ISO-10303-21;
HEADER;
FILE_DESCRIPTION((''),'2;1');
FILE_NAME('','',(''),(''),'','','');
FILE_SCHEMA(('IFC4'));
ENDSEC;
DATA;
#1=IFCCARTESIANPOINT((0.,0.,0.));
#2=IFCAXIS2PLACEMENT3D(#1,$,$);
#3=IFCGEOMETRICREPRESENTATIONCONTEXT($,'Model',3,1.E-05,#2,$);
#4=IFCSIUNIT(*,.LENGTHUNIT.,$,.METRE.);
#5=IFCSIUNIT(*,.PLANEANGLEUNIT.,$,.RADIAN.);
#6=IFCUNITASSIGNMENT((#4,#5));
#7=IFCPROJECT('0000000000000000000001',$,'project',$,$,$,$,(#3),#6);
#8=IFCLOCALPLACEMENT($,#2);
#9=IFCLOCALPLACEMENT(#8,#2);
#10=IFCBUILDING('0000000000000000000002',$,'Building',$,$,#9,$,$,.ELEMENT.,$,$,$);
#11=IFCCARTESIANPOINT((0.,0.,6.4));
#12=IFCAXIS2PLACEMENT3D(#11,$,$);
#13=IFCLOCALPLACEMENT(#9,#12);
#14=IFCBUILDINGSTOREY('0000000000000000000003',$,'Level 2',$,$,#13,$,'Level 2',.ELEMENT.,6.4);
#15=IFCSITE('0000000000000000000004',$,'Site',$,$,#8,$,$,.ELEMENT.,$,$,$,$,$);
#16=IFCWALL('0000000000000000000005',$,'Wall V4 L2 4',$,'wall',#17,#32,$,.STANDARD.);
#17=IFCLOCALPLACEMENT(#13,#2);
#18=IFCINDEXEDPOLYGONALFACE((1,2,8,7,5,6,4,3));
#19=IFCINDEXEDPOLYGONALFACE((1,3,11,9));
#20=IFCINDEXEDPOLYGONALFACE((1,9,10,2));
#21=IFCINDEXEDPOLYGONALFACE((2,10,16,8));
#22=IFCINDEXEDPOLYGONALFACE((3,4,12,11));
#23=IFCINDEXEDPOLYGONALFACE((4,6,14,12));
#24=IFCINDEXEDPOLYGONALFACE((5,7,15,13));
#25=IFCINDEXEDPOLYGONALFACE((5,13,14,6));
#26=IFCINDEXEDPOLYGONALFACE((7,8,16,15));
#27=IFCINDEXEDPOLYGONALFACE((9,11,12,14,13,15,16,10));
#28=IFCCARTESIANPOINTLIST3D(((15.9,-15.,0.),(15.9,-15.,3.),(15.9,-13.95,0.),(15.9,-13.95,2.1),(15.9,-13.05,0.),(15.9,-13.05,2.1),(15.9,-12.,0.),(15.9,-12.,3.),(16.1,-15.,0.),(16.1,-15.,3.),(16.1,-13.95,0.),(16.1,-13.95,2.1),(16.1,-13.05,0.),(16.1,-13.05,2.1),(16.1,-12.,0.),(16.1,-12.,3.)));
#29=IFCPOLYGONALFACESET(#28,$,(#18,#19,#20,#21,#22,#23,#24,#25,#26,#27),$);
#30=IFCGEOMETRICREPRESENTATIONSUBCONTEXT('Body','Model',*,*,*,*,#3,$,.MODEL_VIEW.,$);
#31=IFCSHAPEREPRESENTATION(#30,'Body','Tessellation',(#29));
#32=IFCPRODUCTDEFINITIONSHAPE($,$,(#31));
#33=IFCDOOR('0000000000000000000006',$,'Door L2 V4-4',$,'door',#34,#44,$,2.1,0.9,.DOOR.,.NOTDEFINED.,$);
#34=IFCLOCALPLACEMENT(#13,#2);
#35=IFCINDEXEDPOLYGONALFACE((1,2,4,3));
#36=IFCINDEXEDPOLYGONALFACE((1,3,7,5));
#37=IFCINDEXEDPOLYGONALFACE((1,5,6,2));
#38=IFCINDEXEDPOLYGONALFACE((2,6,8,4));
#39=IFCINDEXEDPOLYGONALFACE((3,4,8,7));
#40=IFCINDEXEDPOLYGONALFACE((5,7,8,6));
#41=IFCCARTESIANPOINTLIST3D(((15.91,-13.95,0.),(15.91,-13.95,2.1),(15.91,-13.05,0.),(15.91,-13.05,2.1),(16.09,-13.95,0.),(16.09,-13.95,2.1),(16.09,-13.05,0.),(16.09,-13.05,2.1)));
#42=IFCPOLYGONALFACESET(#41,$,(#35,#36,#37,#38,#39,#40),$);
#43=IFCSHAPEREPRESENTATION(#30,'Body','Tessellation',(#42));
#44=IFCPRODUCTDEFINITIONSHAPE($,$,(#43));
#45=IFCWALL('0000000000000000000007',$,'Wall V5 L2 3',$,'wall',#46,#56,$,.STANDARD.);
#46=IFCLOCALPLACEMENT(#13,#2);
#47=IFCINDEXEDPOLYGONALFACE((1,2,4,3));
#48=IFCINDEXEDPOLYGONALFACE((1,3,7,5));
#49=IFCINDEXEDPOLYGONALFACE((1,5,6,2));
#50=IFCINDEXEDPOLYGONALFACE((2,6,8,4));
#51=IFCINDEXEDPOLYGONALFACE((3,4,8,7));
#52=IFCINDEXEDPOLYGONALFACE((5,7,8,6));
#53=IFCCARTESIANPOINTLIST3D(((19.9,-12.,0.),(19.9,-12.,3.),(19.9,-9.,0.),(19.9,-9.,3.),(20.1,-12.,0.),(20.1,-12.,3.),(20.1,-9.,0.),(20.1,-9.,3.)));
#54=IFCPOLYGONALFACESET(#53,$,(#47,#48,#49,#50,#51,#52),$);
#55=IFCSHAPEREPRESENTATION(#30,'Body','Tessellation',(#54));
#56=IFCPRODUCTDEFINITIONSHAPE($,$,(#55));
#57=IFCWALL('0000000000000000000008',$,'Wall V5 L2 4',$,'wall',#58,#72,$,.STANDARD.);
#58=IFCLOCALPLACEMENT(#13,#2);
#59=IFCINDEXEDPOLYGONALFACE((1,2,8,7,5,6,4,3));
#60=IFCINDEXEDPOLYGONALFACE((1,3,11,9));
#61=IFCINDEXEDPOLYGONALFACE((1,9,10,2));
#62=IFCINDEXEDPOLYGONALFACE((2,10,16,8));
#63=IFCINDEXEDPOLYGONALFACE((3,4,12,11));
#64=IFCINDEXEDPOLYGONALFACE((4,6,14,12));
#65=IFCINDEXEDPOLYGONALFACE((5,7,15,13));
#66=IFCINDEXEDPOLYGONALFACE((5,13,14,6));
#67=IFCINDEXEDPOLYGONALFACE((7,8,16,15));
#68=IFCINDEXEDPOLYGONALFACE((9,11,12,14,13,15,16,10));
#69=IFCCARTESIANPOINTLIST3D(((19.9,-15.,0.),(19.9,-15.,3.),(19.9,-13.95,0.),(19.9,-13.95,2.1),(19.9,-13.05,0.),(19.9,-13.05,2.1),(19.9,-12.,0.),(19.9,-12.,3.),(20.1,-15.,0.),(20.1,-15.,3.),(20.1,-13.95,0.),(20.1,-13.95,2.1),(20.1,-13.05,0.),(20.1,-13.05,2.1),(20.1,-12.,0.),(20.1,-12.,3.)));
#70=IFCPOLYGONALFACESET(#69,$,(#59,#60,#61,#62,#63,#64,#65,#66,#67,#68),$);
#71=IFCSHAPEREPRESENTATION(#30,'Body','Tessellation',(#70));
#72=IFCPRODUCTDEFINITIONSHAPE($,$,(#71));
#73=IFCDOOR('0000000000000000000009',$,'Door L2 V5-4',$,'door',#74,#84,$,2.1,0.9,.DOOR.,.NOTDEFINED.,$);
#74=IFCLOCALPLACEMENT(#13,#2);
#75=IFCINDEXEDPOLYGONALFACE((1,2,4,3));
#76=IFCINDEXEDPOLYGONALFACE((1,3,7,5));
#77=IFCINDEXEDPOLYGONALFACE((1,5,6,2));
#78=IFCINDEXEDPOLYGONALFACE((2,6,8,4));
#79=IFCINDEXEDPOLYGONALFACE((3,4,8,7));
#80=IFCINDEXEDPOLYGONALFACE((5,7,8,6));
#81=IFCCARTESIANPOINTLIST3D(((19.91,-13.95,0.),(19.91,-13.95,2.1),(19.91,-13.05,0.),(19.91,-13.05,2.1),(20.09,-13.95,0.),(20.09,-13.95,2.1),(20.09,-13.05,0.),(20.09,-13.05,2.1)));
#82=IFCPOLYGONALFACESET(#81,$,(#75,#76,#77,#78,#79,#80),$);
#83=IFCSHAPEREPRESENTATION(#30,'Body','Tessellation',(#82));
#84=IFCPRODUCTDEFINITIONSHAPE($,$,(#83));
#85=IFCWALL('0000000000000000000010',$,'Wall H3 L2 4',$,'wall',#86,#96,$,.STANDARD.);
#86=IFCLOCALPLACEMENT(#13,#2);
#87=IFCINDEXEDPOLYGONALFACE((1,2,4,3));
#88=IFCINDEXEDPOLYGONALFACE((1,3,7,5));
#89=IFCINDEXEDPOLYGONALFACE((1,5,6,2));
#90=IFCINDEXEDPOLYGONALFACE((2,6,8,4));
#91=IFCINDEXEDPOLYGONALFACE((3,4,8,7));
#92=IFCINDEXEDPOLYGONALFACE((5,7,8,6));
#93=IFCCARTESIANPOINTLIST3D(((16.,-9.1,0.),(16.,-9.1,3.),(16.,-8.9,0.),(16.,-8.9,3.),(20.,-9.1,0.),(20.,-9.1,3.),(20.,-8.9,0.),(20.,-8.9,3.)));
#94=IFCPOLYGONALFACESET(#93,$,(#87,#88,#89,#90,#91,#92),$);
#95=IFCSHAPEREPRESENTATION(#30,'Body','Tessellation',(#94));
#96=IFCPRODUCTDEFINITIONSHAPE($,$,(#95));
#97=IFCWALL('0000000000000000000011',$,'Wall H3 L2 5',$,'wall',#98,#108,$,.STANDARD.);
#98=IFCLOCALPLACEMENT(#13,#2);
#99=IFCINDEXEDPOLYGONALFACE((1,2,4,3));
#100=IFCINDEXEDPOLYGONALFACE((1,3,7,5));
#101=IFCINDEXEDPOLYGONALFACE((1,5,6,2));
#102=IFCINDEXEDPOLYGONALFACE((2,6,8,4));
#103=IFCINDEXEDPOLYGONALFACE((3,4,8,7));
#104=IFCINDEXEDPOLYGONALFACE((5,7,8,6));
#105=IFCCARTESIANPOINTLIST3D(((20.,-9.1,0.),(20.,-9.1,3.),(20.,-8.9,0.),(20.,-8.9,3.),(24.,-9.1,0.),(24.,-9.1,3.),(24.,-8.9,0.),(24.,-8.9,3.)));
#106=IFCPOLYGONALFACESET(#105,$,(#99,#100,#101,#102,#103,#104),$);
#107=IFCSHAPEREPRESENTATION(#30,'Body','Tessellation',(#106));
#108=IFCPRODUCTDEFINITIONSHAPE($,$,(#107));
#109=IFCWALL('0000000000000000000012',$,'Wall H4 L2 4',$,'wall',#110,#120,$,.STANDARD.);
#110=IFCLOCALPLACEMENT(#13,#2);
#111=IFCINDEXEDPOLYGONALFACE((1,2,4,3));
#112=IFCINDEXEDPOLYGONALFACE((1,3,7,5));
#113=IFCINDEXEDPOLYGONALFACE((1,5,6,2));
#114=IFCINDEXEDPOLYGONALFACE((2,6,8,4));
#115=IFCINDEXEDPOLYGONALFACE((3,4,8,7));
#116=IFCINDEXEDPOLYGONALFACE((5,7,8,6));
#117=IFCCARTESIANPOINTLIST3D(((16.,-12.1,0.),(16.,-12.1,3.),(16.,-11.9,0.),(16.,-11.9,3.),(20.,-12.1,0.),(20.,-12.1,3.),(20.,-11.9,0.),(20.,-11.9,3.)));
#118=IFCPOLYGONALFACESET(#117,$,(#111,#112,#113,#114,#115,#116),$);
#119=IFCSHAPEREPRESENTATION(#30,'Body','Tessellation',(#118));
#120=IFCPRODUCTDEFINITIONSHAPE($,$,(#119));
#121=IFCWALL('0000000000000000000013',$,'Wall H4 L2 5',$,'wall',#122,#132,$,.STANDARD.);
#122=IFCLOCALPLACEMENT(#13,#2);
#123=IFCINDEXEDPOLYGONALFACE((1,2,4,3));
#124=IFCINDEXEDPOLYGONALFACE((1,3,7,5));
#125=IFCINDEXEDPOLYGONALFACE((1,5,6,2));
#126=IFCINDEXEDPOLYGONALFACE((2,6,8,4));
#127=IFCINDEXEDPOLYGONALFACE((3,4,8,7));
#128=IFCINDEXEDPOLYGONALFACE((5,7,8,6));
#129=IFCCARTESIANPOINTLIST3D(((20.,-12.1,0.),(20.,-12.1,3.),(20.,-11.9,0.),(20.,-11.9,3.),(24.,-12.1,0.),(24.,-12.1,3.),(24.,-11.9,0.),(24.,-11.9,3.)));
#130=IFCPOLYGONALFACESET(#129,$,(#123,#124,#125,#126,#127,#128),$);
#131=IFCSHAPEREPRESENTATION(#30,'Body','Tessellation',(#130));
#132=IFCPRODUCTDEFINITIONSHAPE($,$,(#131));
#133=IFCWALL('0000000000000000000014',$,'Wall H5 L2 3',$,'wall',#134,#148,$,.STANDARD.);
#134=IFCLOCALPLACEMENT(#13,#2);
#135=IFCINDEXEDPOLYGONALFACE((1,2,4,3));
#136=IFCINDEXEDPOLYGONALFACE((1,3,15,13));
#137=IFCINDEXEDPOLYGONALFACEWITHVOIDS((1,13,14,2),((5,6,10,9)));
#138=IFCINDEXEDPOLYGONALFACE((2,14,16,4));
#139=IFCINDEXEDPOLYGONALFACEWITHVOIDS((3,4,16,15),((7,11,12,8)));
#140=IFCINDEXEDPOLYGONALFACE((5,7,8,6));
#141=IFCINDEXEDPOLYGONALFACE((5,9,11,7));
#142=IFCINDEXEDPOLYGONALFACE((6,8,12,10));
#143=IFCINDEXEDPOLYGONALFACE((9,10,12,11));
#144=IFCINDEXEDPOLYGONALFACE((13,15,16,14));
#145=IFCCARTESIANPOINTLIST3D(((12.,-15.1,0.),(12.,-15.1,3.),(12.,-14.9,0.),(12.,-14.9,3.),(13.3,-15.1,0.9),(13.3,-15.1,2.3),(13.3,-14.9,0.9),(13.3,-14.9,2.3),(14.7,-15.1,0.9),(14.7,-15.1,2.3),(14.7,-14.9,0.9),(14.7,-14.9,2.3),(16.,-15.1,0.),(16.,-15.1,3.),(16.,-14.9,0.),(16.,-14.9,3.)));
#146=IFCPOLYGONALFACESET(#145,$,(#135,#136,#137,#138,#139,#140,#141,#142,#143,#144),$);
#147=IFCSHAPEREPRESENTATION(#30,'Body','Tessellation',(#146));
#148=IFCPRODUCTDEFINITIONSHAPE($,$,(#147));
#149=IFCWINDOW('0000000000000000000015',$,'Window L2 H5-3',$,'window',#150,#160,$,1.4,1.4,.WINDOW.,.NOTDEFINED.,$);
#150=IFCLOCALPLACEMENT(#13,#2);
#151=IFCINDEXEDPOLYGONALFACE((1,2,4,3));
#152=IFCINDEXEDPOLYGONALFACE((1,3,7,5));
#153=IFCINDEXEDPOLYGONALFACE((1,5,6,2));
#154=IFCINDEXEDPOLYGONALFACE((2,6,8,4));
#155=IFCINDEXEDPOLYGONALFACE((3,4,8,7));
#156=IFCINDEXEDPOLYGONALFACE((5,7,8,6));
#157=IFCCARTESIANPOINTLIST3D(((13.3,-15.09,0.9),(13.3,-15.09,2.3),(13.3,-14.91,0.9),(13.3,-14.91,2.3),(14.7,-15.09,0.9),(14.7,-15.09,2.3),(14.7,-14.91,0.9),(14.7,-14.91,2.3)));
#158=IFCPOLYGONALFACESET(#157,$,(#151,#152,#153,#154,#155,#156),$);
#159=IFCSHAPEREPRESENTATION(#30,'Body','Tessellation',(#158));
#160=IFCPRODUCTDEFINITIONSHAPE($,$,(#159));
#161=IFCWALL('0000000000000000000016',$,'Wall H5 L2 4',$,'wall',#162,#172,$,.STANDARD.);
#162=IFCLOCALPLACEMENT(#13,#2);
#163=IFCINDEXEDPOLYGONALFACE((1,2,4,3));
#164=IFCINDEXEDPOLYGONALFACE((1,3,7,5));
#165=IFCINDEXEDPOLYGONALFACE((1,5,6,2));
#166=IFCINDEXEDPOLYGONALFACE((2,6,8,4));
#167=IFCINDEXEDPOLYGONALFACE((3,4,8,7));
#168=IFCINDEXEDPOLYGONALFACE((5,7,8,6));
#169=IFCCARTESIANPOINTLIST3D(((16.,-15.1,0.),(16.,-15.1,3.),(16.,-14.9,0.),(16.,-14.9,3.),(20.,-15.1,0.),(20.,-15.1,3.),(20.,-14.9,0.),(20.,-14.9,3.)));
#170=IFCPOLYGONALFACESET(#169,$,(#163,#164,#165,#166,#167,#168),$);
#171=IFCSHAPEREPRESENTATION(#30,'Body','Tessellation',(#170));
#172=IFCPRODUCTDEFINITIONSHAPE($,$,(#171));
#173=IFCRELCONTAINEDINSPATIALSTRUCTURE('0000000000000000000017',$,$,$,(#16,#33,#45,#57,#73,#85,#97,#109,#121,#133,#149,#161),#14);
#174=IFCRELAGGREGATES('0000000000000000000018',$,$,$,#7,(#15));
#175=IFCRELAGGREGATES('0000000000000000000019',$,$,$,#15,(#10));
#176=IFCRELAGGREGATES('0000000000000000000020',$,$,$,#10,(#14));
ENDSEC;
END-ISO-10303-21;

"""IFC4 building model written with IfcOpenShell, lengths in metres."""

from ifc_helpers import new_model, si_unit, frame, frame_2d, origin, origin_2d, place, context, subcontext, project, spatial, rectangle, extrude, element, fill, save


model = new_model("IFC4")

# Units and contexts
model_context = context("Model", 3, precision=1e-05, world=origin())
body_context = subcontext(model_context, "Body", "Model", "MODEL_VIEW")
ifc_project = project(units=[si_unit("LENGTHUNIT", "METRE"), si_unit("PLANEANGLEUNIT", "RADIAN")], contexts=[model_context])

# Site, building, storey
site_placement = place(None, origin())
site = spatial("IfcSite", under=ifc_project, at=site_placement, Name="Site", CompositionType="ELEMENT")
building_placement = place(site_placement, origin())
building = spatial("IfcBuilding", under=site, at=building_placement, Name="Building", CompositionType="ELEMENT")
storey_placement = place(building_placement, frame((0.0, 0.0, 6.4)))
storey = spatial("IfcBuildingStorey", under=building, at=storey_placement, Name="Level 2", LongName="Level 2", CompositionType="ELEMENT", Elevation=6.4)

# Wall, opening, door
wall_1_placement = place(storey_placement, frame((16.0, -12.0, 0.0), z_axis=(0.0, 0.0, 1.0), x_axis=(0.0, -1.0, 0.0)))
wall_1 = element("IfcWall", 1, at=wall_1_placement, inside=storey, Name="Wall V4 L2 4", ObjectType="wall", PredefinedType="STANDARD", context=body_context, shape_type="SweptSolid", body=[
    extrude(rectangle(XDim=3.0, YDim=0.2, at=frame_2d((1.5, 0.0))), origin(), (0.0, 0.0, 1.0), 3.0),
])
opening_1_placement = place(storey_placement, frame((16.0, -13.5, 0.0), z_axis=(0.0, 0.0, 1.0), x_axis=(0.0, -1.0, 0.0)))
opening_1 = element("IfcOpeningElement", 2, at=opening_1_placement, cuts=wall_1, ObjectType="Opening", PredefinedType="OPENING", context=body_context, shape_type="SweptSolid", body=[
    extrude(rectangle(XDim=0.9, YDim=0.22, at=origin_2d()), origin(), (0.0, 0.0, 1.0), 2.1),
])
door_1_placement = place(storey_placement, frame((16.0, -13.5, 0.0), z_axis=(0.0, 0.0, 1.0), x_axis=(0.0, -1.0, 0.0)))
door_1 = element("IfcDoor", 3, at=door_1_placement, inside=storey, Name="Door L2 V4-4", ObjectType="door", OperationType="NOTDEFINED", OverallHeight=2.1, OverallWidth=0.9, PredefinedType="DOOR", context=body_context, shape_type="SweptSolid", body=[
    extrude(rectangle(XDim=0.9, YDim=0.18, at=origin_2d()), origin(), (0.0, 0.0, 1.0), 2.1),
])
fill(opening_1, door_1)

# Wall
wall_2_placement = place(storey_placement, frame((20.0, -9.0, 0.0), z_axis=(0.0, 0.0, 1.0), x_axis=(0.0, -1.0, 0.0)))
element("IfcWall", 4, at=wall_2_placement, inside=storey, Name="Wall V5 L2 3", ObjectType="wall", PredefinedType="STANDARD", context=body_context, shape_type="SweptSolid", body=[
    extrude(rectangle(XDim=3.0, YDim=0.2, at=frame_2d((1.5, 0.0))), origin(), (0.0, 0.0, 1.0), 3.0),
])

# Wall, opening, door
wall_3_placement = place(storey_placement, frame((20.0, -12.0, 0.0), z_axis=(0.0, 0.0, 1.0), x_axis=(0.0, -1.0, 0.0)))
wall_3 = element("IfcWall", 5, at=wall_3_placement, inside=storey, Name="Wall V5 L2 4", ObjectType="wall", PredefinedType="STANDARD", context=body_context, shape_type="SweptSolid", body=[
    extrude(rectangle(XDim=3.0, YDim=0.2, at=frame_2d((1.5, 0.0))), origin(), (0.0, 0.0, 1.0), 3.0),
])
opening_2_placement = place(storey_placement, frame((20.0, -13.5, 0.0), z_axis=(0.0, 0.0, 1.0), x_axis=(0.0, -1.0, 0.0)))
opening_2 = element("IfcOpeningElement", 6, at=opening_2_placement, cuts=wall_3, ObjectType="Opening", PredefinedType="OPENING", context=body_context, shape_type="SweptSolid", body=[
    extrude(rectangle(XDim=0.9, YDim=0.22, at=origin_2d()), origin(), (0.0, 0.0, 1.0), 2.1),
])
door_2_placement = place(storey_placement, frame((20.0, -13.5, 0.0), z_axis=(0.0, 0.0, 1.0), x_axis=(0.0, -1.0, 0.0)))
door_2 = element("IfcDoor", 7, at=door_2_placement, inside=storey, Name="Door L2 V5-4", ObjectType="door", OperationType="NOTDEFINED", OverallHeight=2.1, OverallWidth=0.9, PredefinedType="DOOR", context=body_context, shape_type="SweptSolid", body=[
    extrude(rectangle(XDim=0.9, YDim=0.18, at=origin_2d()), origin(), (0.0, 0.0, 1.0), 2.1),
])
fill(opening_2, door_2)

# Walls
for number, where, z_axis, x_axis, name in (
    (8, (16.0, -9.0, 0.0), (0.0, 0.0, 1.0), (1.0, 0.0, 0.0), "Wall H3 L2 4"),
    (9, (20.0, -9.0, 0.0), (0.0, 0.0, 1.0), (1.0, 0.0, 0.0), "Wall H3 L2 5"),
    (10, (16.0, -12.0, 0.0), (0.0, 0.0, 1.0), (1.0, 0.0, 0.0), "Wall H4 L2 4"),
    (11, (20.0, -12.0, 0.0), (0.0, 0.0, 1.0), (1.0, 0.0, 0.0), "Wall H4 L2 5"),
):
    element("IfcWall", number, at=place(storey_placement, frame(where, z_axis=z_axis, x_axis=x_axis)), inside=storey, Name=name, ObjectType="wall", PredefinedType="STANDARD", context=body_context, shape_type="SweptSolid", body=[
        extrude(rectangle(XDim=4.0, YDim=0.2, at=frame_2d((2.0, 0.0))), origin(), (0.0, 0.0, 1.0), 3.0),
    ])

# Wall, opening, window
wall_4_placement = place(storey_placement, frame((12.0, -15.0, 0.0), z_axis=(0.0, 0.0, 1.0), x_axis=(1.0, 0.0, 0.0)))
wall_4 = element("IfcWall", 12, at=wall_4_placement, inside=storey, Name="Wall H5 L2 3", ObjectType="wall", PredefinedType="STANDARD", context=body_context, shape_type="SweptSolid", body=[
    extrude(rectangle(XDim=4.0, YDim=0.2, at=frame_2d((2.0, 0.0))), origin(), (0.0, 0.0, 1.0), 3.0),
])
opening_3_placement = place(storey_placement, frame((14.0, -15.0, 0.9), z_axis=(0.0, 0.0, 1.0), x_axis=(1.0, 0.0, 0.0)))
opening_3 = element("IfcOpeningElement", 13, at=opening_3_placement, cuts=wall_4, ObjectType="Opening", PredefinedType="OPENING", context=body_context, shape_type="SweptSolid", body=[
    extrude(rectangle(XDim=1.4, YDim=0.22, at=origin_2d()), origin(), (0.0, 0.0, 1.0), 1.4),
])
window_1_placement = place(storey_placement, frame((14.0, -15.0, 0.9), z_axis=(0.0, 0.0, 1.0), x_axis=(1.0, 0.0, 0.0)))
window_1 = element("IfcWindow", 14, at=window_1_placement, inside=storey, Name="Window L2 H5-3", ObjectType="window", OverallHeight=1.4, OverallWidth=1.4, PartitioningType="NOTDEFINED", PredefinedType="WINDOW", context=body_context, shape_type="SweptSolid", body=[
    extrude(rectangle(XDim=1.4, YDim=0.18, at=origin_2d()), origin(), (0.0, 0.0, 1.0), 1.4),
])
fill(opening_3, window_1)

# Wall
wall_5_placement = place(storey_placement, frame((16.0, -15.0, 0.0), z_axis=(0.0, 0.0, 1.0), x_axis=(1.0, 0.0, 0.0)))
element("IfcWall", 15, at=wall_5_placement, inside=storey, Name="Wall H5 L2 4", ObjectType="wall", PredefinedType="STANDARD", context=body_context, shape_type="SweptSolid", body=[
    extrude(rectangle(XDim=4.0, YDim=0.2, at=frame_2d((2.0, 0.0))), origin(), (0.0, 0.0, 1.0), 3.0),
])

save(model, "model.ifc")
